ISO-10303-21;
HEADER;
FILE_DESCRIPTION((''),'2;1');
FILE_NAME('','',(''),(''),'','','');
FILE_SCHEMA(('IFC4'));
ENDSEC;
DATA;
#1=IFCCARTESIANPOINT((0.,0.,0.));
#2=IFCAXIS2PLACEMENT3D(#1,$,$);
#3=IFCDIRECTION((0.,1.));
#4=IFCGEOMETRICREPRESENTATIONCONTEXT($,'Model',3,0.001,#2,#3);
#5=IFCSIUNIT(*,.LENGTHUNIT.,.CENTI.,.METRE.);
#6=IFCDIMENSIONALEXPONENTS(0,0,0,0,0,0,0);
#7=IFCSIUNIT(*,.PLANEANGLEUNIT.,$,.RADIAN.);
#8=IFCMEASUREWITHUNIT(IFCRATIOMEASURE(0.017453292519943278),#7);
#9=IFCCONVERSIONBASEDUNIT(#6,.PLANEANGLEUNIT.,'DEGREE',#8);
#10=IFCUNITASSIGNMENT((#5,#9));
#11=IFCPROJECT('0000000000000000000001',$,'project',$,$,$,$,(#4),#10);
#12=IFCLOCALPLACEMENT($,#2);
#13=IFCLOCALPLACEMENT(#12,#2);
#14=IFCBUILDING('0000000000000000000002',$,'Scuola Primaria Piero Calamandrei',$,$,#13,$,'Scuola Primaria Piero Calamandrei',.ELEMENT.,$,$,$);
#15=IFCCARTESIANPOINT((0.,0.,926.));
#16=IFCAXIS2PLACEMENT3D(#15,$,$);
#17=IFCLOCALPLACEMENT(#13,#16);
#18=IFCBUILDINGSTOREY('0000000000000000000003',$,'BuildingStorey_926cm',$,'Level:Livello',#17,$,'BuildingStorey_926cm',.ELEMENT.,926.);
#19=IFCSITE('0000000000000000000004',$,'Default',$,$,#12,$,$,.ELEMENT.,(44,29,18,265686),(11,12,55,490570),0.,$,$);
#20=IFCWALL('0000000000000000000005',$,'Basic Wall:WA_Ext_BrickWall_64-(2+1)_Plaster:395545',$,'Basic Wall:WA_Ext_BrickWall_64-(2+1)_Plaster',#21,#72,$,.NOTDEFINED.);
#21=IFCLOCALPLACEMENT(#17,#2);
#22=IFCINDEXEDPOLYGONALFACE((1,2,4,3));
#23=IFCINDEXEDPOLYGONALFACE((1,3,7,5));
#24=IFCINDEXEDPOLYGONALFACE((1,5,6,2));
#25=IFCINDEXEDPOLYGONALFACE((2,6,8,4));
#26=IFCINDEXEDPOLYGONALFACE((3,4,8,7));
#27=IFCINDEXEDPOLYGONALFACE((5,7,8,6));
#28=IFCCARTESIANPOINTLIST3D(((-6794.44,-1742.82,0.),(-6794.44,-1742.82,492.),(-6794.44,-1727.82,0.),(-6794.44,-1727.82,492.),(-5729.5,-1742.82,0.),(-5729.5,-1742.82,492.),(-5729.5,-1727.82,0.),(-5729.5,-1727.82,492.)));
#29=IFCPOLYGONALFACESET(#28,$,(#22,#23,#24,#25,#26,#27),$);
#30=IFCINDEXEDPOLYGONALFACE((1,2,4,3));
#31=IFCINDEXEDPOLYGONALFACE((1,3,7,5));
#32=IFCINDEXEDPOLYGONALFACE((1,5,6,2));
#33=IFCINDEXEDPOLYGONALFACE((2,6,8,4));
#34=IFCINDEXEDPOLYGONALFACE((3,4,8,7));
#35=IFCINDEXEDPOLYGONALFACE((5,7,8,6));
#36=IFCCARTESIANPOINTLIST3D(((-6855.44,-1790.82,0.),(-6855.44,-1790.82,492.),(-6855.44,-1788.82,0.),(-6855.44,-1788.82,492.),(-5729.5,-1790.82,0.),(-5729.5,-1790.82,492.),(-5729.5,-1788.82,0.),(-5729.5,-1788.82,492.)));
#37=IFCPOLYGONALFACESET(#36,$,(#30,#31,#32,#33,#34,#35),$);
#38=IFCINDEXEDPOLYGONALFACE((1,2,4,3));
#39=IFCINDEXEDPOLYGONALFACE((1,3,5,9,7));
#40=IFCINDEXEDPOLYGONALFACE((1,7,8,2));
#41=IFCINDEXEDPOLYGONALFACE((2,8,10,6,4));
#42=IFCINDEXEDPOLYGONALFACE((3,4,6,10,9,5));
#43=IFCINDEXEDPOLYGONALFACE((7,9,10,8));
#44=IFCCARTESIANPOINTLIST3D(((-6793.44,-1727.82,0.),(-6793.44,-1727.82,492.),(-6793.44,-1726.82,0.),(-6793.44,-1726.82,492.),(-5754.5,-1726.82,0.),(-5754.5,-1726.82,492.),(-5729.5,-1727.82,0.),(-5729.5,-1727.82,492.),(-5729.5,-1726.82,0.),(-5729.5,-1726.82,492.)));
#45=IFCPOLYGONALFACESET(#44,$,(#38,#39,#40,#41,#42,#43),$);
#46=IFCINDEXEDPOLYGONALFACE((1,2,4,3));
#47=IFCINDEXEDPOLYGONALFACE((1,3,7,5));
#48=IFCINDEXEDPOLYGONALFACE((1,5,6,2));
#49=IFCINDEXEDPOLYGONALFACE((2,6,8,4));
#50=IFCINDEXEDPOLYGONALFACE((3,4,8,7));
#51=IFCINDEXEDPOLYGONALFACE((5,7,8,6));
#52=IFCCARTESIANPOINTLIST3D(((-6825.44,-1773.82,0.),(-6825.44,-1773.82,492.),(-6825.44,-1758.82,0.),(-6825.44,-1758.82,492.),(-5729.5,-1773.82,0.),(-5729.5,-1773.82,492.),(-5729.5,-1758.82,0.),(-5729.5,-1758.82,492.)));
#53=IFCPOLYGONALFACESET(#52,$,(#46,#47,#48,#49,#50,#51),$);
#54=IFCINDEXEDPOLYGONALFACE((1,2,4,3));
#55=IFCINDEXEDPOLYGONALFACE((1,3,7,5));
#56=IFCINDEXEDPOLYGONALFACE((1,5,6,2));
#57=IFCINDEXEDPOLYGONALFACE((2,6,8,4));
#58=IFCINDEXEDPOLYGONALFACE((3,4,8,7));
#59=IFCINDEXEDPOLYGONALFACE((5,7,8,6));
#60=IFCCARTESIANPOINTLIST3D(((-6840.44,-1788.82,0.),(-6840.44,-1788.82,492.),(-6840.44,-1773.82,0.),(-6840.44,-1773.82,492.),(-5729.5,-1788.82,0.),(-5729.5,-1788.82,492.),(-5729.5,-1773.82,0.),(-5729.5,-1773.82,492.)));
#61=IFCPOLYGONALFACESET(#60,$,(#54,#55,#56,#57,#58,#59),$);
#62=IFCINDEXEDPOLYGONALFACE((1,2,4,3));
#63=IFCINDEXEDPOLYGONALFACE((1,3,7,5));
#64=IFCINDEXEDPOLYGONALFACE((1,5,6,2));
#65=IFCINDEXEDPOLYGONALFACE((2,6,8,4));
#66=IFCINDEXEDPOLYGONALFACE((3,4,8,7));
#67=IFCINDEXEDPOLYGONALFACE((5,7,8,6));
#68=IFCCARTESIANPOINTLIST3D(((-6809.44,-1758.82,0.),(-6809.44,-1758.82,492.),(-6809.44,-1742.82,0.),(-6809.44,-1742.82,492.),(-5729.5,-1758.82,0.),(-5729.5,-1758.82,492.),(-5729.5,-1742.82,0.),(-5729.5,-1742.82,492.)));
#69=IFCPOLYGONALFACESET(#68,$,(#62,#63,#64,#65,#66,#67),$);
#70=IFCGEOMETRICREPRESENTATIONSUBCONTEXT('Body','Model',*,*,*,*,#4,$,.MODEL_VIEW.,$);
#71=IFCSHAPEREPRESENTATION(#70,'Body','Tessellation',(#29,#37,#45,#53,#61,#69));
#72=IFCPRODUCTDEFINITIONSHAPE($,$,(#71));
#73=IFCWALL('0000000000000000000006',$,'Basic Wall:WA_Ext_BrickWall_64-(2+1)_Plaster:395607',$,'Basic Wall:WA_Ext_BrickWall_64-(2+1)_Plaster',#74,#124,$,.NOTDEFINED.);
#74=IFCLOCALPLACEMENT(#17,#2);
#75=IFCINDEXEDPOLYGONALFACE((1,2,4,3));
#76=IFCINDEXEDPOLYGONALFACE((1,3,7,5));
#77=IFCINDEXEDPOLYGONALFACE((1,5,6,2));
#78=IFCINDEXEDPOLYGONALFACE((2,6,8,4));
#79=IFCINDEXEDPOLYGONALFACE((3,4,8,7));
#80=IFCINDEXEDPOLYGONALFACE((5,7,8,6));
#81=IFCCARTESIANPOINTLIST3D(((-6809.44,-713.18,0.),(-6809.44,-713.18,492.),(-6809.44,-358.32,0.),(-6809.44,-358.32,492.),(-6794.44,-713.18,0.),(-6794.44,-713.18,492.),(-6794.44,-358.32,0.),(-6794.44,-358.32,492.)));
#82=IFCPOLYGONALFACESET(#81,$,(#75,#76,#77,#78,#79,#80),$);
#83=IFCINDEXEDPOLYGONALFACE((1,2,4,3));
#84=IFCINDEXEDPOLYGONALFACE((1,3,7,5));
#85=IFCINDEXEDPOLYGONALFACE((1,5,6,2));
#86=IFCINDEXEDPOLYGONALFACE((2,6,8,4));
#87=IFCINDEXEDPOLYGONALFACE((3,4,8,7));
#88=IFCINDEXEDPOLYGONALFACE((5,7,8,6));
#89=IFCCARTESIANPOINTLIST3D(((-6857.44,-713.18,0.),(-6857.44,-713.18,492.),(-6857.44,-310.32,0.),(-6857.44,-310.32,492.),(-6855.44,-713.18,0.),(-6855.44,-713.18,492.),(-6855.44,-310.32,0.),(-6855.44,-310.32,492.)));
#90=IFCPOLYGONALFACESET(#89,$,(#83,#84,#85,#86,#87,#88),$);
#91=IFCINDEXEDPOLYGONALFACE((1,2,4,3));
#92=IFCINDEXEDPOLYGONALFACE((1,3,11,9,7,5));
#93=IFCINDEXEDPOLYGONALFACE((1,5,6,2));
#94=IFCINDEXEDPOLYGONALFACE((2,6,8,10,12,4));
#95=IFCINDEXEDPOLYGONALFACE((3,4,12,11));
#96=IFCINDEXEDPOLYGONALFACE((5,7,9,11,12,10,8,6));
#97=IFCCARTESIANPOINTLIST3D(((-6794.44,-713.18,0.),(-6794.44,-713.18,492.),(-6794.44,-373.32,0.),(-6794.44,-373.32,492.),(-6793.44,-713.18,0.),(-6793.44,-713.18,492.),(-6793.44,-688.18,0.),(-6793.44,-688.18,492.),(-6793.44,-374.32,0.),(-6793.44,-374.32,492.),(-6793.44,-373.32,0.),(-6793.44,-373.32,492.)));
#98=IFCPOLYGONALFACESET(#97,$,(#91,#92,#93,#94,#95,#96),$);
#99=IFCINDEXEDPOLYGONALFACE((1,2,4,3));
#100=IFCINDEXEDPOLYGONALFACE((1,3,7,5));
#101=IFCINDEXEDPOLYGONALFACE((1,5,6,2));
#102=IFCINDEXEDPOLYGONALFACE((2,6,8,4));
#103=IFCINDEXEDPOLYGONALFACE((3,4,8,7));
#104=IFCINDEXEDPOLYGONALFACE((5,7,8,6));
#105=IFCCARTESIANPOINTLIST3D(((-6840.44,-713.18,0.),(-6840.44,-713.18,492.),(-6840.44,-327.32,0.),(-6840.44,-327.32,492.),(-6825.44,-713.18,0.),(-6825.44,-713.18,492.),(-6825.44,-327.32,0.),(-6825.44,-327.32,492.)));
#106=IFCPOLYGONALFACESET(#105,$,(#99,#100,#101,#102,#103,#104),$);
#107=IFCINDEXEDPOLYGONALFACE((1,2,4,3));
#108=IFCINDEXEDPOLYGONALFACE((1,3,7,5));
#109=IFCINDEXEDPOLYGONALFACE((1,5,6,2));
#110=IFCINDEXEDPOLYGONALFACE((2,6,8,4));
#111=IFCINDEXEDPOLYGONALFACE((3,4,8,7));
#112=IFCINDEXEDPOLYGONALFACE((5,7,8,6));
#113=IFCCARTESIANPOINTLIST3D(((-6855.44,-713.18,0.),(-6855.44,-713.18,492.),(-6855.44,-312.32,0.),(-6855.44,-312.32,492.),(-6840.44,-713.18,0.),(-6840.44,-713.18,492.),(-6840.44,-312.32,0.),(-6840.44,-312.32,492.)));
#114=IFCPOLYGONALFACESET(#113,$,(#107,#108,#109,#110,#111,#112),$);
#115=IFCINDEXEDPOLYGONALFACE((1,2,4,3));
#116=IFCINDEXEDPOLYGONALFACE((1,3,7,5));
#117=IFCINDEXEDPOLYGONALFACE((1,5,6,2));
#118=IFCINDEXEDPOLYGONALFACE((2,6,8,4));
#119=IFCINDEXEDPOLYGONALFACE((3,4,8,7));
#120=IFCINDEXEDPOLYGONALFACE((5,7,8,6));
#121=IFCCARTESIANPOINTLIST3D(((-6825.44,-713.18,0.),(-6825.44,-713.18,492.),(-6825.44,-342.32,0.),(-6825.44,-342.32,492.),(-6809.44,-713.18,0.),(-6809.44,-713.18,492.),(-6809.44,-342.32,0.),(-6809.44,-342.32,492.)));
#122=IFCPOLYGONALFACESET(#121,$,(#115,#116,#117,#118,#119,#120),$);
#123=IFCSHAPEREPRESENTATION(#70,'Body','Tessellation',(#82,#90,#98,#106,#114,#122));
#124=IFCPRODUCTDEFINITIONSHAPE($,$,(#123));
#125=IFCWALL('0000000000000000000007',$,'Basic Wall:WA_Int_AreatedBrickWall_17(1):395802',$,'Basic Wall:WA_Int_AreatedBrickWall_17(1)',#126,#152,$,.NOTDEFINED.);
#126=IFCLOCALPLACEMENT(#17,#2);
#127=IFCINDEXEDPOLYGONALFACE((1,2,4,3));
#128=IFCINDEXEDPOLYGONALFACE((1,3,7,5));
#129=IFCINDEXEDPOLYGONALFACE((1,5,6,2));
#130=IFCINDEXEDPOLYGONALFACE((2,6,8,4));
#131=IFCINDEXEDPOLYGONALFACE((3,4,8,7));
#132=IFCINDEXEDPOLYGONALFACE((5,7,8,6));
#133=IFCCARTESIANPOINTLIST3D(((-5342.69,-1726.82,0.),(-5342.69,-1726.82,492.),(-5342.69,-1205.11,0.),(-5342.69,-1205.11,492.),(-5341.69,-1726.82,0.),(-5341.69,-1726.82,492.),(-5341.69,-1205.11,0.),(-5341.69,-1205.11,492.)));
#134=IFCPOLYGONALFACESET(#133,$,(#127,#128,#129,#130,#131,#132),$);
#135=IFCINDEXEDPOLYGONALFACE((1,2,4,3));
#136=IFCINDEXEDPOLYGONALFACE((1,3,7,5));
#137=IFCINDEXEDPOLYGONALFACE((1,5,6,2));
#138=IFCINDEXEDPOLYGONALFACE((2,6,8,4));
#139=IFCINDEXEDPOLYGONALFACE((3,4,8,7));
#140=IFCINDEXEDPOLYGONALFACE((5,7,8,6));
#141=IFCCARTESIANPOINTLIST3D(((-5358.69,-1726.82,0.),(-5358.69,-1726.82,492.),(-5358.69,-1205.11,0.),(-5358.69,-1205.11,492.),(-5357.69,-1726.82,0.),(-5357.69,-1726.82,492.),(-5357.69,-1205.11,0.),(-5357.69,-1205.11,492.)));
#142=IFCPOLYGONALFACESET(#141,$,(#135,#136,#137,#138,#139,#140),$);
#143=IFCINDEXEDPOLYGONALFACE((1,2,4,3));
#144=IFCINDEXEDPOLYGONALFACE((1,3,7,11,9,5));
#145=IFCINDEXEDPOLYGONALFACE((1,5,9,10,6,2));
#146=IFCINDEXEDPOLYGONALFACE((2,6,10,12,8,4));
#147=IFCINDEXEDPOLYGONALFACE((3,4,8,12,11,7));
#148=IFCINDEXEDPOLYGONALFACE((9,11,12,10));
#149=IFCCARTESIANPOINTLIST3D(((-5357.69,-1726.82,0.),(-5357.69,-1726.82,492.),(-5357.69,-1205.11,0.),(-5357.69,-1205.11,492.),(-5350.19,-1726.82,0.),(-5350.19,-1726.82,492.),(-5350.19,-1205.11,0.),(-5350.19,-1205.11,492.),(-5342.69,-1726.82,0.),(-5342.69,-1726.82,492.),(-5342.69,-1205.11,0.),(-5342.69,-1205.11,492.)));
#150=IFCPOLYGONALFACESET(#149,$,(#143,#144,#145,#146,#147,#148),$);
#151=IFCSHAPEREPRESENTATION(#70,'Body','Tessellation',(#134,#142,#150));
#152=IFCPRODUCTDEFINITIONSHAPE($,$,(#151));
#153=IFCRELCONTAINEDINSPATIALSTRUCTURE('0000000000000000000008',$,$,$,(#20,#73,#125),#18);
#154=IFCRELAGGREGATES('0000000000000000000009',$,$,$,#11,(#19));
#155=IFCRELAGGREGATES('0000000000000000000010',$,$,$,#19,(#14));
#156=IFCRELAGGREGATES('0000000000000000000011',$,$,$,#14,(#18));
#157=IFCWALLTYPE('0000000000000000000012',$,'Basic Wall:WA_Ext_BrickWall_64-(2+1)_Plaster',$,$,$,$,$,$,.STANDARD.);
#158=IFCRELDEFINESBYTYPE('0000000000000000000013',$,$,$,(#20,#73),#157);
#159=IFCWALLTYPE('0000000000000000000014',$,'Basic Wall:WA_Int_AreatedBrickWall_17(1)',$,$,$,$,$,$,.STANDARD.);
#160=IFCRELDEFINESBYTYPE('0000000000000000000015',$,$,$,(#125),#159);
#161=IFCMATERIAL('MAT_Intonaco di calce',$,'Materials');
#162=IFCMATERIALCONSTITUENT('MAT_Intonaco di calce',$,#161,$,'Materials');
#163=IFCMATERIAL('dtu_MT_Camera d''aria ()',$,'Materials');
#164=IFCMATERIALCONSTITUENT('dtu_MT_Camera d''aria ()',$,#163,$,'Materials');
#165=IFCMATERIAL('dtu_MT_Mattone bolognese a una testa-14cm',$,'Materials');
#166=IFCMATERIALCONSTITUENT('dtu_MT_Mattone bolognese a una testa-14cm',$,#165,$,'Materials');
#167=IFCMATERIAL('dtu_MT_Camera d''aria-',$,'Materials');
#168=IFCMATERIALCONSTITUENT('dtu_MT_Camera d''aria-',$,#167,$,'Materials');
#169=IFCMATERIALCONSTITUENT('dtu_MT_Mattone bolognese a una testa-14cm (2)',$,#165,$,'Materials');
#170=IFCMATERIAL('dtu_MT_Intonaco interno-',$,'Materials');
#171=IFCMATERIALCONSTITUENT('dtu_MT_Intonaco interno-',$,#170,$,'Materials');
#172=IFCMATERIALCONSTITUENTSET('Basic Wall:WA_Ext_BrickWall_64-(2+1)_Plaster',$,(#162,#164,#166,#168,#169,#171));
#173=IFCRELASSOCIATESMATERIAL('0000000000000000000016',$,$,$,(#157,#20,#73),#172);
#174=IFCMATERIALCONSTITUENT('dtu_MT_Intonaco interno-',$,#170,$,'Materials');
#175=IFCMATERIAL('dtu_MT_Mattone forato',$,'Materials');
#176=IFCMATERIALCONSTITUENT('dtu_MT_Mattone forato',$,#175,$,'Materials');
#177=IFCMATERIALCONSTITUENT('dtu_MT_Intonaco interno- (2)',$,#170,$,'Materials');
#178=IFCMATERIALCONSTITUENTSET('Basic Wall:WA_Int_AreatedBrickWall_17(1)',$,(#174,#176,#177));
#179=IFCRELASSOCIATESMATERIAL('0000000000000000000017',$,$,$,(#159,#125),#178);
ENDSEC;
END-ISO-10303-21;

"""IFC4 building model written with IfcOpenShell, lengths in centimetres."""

from ifc_helpers import new_model, entity, si_unit, converted_unit, direction, frame, origin, place, context, subcontext, project, spatial, indexed_curve, outline, extrude, material, constituent, constituent_set, type_object, element, save


model = new_model("IFC4")

# Units and contexts
model_context = context("Model", 3, precision=0.001, world=origin(), true_north=direction((0.0, 1.0)))
body_context = subcontext(model_context, "Body", "Model", "MODEL_VIEW")
ifc_project = project(units=[si_unit("LENGTHUNIT", "METRE", prefix="CENTI"), converted_unit("PLANEANGLEUNIT", "DEGREE", entity("IfcRatioMeasure", 0.017453292519943278), si_unit("PLANEANGLEUNIT", "RADIAN"), dimensions=[0, 0, 0, 0, 0, 0, 0])], contexts=[model_context])

# Site, building, storey
site_placement = place(None, origin())
site = spatial("IfcSite", under=ifc_project, at=site_placement, Name="Default", CompositionType="ELEMENT", RefLatitude=(44, 29, 18, 265686), RefLongitude=(11, 12, 55, 490570), RefElevation=0.0)
building_placement = place(site_placement, origin())
building = spatial("IfcBuilding", under=site, at=building_placement, Name="Scuola Primaria Piero Calamandrei", LongName="Scuola Primaria Piero Calamandrei", CompositionType="ELEMENT")
storey_placement = place(building_placement, frame((0.0, 0.0, 926.0)))
storey = spatial("IfcBuildingStorey", under=building, at=storey_placement, Name="BuildingStorey_926cm", ObjectType="Level:Livello", LongName="BuildingStorey_926cm", CompositionType="ELEMENT", Elevation=926.0)

# Shared definitions
ifc_material_1 = material(Name="MAT_Intonaco di calce", Category="Materials")
ifc_constituent_1 = constituent(ifc_material_1, Name="MAT_Intonaco di calce", Category="Materials")
ifc_material_2 = material(Name="dtu_MT_Camera d'aria ()", Category="Materials")
ifc_constituent_2 = constituent(ifc_material_2, Name="dtu_MT_Camera d'aria ()", Category="Materials")
ifc_material_3 = material(Name="dtu_MT_Mattone bolognese a una testa-14cm", Category="Materials")
ifc_constituent_3 = constituent(ifc_material_3, Name="dtu_MT_Mattone bolognese a una testa-14cm", Category="Materials")
ifc_material_4 = material(Name="dtu_MT_Camera d'aria-", Category="Materials")
ifc_constituent_4 = constituent(ifc_material_4, Name="dtu_MT_Camera d'aria-", Category="Materials")
ifc_constituent_5 = constituent(ifc_material_3, Name="dtu_MT_Mattone bolognese a una testa-14cm (2)", Category="Materials")
ifc_material_5 = material(Name="dtu_MT_Intonaco interno-", Category="Materials")
ifc_constituent_6 = constituent(ifc_material_5, Name="dtu_MT_Intonaco interno-", Category="Materials")
ifc_constituent_set_1 = constituent_set(constituents=[ifc_constituent_1, ifc_constituent_2, ifc_constituent_3, ifc_constituent_4, ifc_constituent_5, ifc_constituent_6], Name="Basic Wall:WA_Ext_BrickWall_64-(2+1)_Plaster")
wall_type_1 = type_object("IfcWallType", Name="Basic Wall:WA_Ext_BrickWall_64-(2+1)_Plaster", PredefinedType="STANDARD", material=ifc_constituent_set_1)

# Walls
wall_1_placement = place(storey_placement, frame((-5729.5, -1758.82, 0.0), z_axis=(0.0, 0.0, 1.0), x_axis=(-1.0, 0.0, 0.0)))
element("IfcWall", 1, at=wall_1_placement, inside=storey, type_object=wall_type_1, material=ifc_constituent_set_1, Name="Basic Wall:WA_Ext_BrickWall_64-(2+1)_Plaster:395545", ObjectType="Basic Wall:WA_Ext_BrickWall_64-(2+1)_Plaster", PredefinedType="NOTDEFINED", context=body_context, shape_type="SweptSolid", body=[
    extrude(outline(indexed_curve([(-532.47, -7.5), (532.47, -7.5), (532.47, 7.5), (-532.47, 7.5), (-532.47, -7.5)], self_intersect=False)), frame((532.47, -23.5, 0.0)), (0.0, 0.0, 1.0), 492.0),
    extrude(outline(indexed_curve([(-1.0, -562.97), (1.0, -562.97), (1.0, 562.97), (-1.0, 562.97), (-1.0, -562.97)], self_intersect=False)), frame((562.97, 31.0, 0.0), z_axis=(0.0, 0.0, 1.0), x_axis=(0.0, -1.0, 0.0)), (0.0, 0.0, 1.0), 492.0),
    extrude(outline(indexed_curve([(-405.58, -0.4), (633.37, -0.4), (633.37, 0.6), (-430.58, 0.6), (-430.58, -0.4), (-405.58, -0.4)], self_intersect=False)), frame((430.58, -31.6, 0.0)), (0.0, 0.0, 1.0), 492.0),
    extrude(outline(indexed_curve([(-547.97, -7.5), (547.97, -7.5), (547.97, 7.5), (-547.97, 7.5), (-547.97, -7.5)], self_intersect=False)), frame((547.97, 7.5, 0.0)), (0.0, 0.0, 1.0), 492.0),
    extrude(outline(indexed_curve([(-555.47, -7.5), (555.47, -7.5), (555.47, 7.5), (-555.47, 7.5), (-555.47, -7.5)], self_intersect=False)), frame((555.47, 22.5, 0.0)), (0.0, 0.0, 1.0), 492.0),
    extrude(outline(indexed_curve([(-539.97, -8.0), (539.97, -8.0), (539.97, 8.0), (-539.97, 8.0), (-539.97, -8.0)], self_intersect=False)), frame((539.97, -8.0, 0.0)), (0.0, 0.0, 1.0), 492.0),
])
wall_2_placement = place(storey_placement, frame((-6825.44, -713.18, 0.0), z_axis=(0.0, 0.0, 1.0), x_axis=(0.0, 1.0, 0.0)))
element("IfcWall", 2, at=wall_2_placement, inside=storey, type_object=wall_type_1, material=ifc_constituent_set_1, Name="Basic Wall:WA_Ext_BrickWall_64-(2+1)_Plaster:395607", ObjectType="Basic Wall:WA_Ext_BrickWall_64-(2+1)_Plaster", PredefinedType="NOTDEFINED", context=body_context, shape_type="SweptSolid", body=[
    extrude(outline(indexed_curve([(-177.43, -7.5), (177.43, -7.5), (177.43, 7.5), (-177.43, 7.5), (-177.43, -7.5)], self_intersect=False)), frame((177.43, -23.5, 0.0)), (0.0, 0.0, 1.0), 492.0),
    extrude(outline(indexed_curve([(-1.0, -201.43), (1.0, -201.43), (1.0, 201.43), (-1.0, 201.43), (-1.0, -201.43)], self_intersect=False)), frame((201.43, 31.0, 0.0), z_axis=(0.0, 0.0, 1.0), x_axis=(0.0, -1.0, 0.0)), (0.0, 0.0, 1.0), 492.0),
    extrude(outline(indexed_curve([(-148.93, -0.33), (164.93, -0.33), (165.93, -0.33), (165.93, 0.67), (-173.93, 0.67), (-173.93, -0.33), (-148.93, -0.33)], self_intersect=False)), frame((173.93, -31.67, 0.0)), (0.0, 0.0, 1.0), 492.0),
    extrude(outline(indexed_curve([(-192.93, -7.5), (192.93, -7.5), (192.93, 7.5), (-192.93, 7.5), (-192.93, -7.5)], self_intersect=False)), frame((192.93, 7.5, 0.0)), (0.0, 0.0, 1.0), 492.0),
    extrude(outline(indexed_curve([(-200.43, -7.5), (200.43, -7.5), (200.43, 7.5), (-200.43, 7.5), (-200.43, -7.5)], self_intersect=False)), frame((200.43, 22.5, 0.0)), (0.0, 0.0, 1.0), 492.0),
    extrude(outline(indexed_curve([(-185.43, -8.0), (185.43, -8.0), (185.43, 8.0), (-185.43, 8.0), (-185.43, -8.0)], self_intersect=False)), frame((185.43, -8.0, 0.0)), (0.0, 0.0, 1.0), 492.0),
])

# Shared definitions
ifc_constituent_7 = constituent(ifc_material_5, Name="dtu_MT_Intonaco interno-", Category="Materials")
ifc_material_6 = material(Name="dtu_MT_Mattone forato", Category="Materials")
ifc_constituent_8 = constituent(ifc_material_6, Name="dtu_MT_Mattone forato", Category="Materials")
ifc_constituent_9 = constituent(ifc_material_5, Name="dtu_MT_Intonaco interno- (2)", Category="Materials")
ifc_constituent_set_2 = constituent_set(constituents=[ifc_constituent_7, ifc_constituent_8, ifc_constituent_9], Name="Basic Wall:WA_Int_AreatedBrickWall_17(1)")
wall_type_2 = type_object("IfcWallType", Name="Basic Wall:WA_Int_AreatedBrickWall_17(1)", PredefinedType="STANDARD", material=ifc_constituent_set_2)

# Wall
wall_3_placement = place(storey_placement, frame((-5350.19, -1726.82, 0.0), z_axis=(0.0, 0.0, 1.0), x_axis=(0.0, 1.0, 0.0)))
element("IfcWall", 3, at=wall_3_placement, inside=storey, type_object=wall_type_2, material=ifc_constituent_set_2, Name="Basic Wall:WA_Int_AreatedBrickWall_17(1):395802", ObjectType="Basic Wall:WA_Int_AreatedBrickWall_17(1)", PredefinedType="NOTDEFINED", context=body_context, shape_type="SweptSolid", body=[
    extrude(outline(indexed_curve([(-0.5, -260.86), (0.5, -260.86), (0.5, 260.86), (-0.5, 260.86), (-0.5, -260.86)], self_intersect=False)), frame((260.86, -8.0, 0.0), z_axis=(0.0, 0.0, 1.0), x_axis=(0.0, 1.0, 0.0)), (0.0, 0.0, 1.0), 492.0),
    extrude(outline(indexed_curve([(-0.5, -260.86), (0.5, -260.86), (0.5, 260.86), (-0.5, 260.86), (-0.5, -260.86)], self_intersect=False)), frame((260.86, 8.0, 0.0), z_axis=(0.0, 0.0, 1.0), x_axis=(0.0, -1.0, 0.0)), (0.0, 0.0, 1.0), 492.0),
    extrude(outline(indexed_curve([(-260.86, -7.5), (260.86, -7.5), (260.86, 0.0), (260.86, 7.5), (-260.86, 7.5), (-260.86, 0.0), (-260.86, -7.5)], self_intersect=False)), frame((260.86, 0.0, 0.0)), (0.0, 0.0, 1.0), 492.0),
])

save(model, "model.ifc")
